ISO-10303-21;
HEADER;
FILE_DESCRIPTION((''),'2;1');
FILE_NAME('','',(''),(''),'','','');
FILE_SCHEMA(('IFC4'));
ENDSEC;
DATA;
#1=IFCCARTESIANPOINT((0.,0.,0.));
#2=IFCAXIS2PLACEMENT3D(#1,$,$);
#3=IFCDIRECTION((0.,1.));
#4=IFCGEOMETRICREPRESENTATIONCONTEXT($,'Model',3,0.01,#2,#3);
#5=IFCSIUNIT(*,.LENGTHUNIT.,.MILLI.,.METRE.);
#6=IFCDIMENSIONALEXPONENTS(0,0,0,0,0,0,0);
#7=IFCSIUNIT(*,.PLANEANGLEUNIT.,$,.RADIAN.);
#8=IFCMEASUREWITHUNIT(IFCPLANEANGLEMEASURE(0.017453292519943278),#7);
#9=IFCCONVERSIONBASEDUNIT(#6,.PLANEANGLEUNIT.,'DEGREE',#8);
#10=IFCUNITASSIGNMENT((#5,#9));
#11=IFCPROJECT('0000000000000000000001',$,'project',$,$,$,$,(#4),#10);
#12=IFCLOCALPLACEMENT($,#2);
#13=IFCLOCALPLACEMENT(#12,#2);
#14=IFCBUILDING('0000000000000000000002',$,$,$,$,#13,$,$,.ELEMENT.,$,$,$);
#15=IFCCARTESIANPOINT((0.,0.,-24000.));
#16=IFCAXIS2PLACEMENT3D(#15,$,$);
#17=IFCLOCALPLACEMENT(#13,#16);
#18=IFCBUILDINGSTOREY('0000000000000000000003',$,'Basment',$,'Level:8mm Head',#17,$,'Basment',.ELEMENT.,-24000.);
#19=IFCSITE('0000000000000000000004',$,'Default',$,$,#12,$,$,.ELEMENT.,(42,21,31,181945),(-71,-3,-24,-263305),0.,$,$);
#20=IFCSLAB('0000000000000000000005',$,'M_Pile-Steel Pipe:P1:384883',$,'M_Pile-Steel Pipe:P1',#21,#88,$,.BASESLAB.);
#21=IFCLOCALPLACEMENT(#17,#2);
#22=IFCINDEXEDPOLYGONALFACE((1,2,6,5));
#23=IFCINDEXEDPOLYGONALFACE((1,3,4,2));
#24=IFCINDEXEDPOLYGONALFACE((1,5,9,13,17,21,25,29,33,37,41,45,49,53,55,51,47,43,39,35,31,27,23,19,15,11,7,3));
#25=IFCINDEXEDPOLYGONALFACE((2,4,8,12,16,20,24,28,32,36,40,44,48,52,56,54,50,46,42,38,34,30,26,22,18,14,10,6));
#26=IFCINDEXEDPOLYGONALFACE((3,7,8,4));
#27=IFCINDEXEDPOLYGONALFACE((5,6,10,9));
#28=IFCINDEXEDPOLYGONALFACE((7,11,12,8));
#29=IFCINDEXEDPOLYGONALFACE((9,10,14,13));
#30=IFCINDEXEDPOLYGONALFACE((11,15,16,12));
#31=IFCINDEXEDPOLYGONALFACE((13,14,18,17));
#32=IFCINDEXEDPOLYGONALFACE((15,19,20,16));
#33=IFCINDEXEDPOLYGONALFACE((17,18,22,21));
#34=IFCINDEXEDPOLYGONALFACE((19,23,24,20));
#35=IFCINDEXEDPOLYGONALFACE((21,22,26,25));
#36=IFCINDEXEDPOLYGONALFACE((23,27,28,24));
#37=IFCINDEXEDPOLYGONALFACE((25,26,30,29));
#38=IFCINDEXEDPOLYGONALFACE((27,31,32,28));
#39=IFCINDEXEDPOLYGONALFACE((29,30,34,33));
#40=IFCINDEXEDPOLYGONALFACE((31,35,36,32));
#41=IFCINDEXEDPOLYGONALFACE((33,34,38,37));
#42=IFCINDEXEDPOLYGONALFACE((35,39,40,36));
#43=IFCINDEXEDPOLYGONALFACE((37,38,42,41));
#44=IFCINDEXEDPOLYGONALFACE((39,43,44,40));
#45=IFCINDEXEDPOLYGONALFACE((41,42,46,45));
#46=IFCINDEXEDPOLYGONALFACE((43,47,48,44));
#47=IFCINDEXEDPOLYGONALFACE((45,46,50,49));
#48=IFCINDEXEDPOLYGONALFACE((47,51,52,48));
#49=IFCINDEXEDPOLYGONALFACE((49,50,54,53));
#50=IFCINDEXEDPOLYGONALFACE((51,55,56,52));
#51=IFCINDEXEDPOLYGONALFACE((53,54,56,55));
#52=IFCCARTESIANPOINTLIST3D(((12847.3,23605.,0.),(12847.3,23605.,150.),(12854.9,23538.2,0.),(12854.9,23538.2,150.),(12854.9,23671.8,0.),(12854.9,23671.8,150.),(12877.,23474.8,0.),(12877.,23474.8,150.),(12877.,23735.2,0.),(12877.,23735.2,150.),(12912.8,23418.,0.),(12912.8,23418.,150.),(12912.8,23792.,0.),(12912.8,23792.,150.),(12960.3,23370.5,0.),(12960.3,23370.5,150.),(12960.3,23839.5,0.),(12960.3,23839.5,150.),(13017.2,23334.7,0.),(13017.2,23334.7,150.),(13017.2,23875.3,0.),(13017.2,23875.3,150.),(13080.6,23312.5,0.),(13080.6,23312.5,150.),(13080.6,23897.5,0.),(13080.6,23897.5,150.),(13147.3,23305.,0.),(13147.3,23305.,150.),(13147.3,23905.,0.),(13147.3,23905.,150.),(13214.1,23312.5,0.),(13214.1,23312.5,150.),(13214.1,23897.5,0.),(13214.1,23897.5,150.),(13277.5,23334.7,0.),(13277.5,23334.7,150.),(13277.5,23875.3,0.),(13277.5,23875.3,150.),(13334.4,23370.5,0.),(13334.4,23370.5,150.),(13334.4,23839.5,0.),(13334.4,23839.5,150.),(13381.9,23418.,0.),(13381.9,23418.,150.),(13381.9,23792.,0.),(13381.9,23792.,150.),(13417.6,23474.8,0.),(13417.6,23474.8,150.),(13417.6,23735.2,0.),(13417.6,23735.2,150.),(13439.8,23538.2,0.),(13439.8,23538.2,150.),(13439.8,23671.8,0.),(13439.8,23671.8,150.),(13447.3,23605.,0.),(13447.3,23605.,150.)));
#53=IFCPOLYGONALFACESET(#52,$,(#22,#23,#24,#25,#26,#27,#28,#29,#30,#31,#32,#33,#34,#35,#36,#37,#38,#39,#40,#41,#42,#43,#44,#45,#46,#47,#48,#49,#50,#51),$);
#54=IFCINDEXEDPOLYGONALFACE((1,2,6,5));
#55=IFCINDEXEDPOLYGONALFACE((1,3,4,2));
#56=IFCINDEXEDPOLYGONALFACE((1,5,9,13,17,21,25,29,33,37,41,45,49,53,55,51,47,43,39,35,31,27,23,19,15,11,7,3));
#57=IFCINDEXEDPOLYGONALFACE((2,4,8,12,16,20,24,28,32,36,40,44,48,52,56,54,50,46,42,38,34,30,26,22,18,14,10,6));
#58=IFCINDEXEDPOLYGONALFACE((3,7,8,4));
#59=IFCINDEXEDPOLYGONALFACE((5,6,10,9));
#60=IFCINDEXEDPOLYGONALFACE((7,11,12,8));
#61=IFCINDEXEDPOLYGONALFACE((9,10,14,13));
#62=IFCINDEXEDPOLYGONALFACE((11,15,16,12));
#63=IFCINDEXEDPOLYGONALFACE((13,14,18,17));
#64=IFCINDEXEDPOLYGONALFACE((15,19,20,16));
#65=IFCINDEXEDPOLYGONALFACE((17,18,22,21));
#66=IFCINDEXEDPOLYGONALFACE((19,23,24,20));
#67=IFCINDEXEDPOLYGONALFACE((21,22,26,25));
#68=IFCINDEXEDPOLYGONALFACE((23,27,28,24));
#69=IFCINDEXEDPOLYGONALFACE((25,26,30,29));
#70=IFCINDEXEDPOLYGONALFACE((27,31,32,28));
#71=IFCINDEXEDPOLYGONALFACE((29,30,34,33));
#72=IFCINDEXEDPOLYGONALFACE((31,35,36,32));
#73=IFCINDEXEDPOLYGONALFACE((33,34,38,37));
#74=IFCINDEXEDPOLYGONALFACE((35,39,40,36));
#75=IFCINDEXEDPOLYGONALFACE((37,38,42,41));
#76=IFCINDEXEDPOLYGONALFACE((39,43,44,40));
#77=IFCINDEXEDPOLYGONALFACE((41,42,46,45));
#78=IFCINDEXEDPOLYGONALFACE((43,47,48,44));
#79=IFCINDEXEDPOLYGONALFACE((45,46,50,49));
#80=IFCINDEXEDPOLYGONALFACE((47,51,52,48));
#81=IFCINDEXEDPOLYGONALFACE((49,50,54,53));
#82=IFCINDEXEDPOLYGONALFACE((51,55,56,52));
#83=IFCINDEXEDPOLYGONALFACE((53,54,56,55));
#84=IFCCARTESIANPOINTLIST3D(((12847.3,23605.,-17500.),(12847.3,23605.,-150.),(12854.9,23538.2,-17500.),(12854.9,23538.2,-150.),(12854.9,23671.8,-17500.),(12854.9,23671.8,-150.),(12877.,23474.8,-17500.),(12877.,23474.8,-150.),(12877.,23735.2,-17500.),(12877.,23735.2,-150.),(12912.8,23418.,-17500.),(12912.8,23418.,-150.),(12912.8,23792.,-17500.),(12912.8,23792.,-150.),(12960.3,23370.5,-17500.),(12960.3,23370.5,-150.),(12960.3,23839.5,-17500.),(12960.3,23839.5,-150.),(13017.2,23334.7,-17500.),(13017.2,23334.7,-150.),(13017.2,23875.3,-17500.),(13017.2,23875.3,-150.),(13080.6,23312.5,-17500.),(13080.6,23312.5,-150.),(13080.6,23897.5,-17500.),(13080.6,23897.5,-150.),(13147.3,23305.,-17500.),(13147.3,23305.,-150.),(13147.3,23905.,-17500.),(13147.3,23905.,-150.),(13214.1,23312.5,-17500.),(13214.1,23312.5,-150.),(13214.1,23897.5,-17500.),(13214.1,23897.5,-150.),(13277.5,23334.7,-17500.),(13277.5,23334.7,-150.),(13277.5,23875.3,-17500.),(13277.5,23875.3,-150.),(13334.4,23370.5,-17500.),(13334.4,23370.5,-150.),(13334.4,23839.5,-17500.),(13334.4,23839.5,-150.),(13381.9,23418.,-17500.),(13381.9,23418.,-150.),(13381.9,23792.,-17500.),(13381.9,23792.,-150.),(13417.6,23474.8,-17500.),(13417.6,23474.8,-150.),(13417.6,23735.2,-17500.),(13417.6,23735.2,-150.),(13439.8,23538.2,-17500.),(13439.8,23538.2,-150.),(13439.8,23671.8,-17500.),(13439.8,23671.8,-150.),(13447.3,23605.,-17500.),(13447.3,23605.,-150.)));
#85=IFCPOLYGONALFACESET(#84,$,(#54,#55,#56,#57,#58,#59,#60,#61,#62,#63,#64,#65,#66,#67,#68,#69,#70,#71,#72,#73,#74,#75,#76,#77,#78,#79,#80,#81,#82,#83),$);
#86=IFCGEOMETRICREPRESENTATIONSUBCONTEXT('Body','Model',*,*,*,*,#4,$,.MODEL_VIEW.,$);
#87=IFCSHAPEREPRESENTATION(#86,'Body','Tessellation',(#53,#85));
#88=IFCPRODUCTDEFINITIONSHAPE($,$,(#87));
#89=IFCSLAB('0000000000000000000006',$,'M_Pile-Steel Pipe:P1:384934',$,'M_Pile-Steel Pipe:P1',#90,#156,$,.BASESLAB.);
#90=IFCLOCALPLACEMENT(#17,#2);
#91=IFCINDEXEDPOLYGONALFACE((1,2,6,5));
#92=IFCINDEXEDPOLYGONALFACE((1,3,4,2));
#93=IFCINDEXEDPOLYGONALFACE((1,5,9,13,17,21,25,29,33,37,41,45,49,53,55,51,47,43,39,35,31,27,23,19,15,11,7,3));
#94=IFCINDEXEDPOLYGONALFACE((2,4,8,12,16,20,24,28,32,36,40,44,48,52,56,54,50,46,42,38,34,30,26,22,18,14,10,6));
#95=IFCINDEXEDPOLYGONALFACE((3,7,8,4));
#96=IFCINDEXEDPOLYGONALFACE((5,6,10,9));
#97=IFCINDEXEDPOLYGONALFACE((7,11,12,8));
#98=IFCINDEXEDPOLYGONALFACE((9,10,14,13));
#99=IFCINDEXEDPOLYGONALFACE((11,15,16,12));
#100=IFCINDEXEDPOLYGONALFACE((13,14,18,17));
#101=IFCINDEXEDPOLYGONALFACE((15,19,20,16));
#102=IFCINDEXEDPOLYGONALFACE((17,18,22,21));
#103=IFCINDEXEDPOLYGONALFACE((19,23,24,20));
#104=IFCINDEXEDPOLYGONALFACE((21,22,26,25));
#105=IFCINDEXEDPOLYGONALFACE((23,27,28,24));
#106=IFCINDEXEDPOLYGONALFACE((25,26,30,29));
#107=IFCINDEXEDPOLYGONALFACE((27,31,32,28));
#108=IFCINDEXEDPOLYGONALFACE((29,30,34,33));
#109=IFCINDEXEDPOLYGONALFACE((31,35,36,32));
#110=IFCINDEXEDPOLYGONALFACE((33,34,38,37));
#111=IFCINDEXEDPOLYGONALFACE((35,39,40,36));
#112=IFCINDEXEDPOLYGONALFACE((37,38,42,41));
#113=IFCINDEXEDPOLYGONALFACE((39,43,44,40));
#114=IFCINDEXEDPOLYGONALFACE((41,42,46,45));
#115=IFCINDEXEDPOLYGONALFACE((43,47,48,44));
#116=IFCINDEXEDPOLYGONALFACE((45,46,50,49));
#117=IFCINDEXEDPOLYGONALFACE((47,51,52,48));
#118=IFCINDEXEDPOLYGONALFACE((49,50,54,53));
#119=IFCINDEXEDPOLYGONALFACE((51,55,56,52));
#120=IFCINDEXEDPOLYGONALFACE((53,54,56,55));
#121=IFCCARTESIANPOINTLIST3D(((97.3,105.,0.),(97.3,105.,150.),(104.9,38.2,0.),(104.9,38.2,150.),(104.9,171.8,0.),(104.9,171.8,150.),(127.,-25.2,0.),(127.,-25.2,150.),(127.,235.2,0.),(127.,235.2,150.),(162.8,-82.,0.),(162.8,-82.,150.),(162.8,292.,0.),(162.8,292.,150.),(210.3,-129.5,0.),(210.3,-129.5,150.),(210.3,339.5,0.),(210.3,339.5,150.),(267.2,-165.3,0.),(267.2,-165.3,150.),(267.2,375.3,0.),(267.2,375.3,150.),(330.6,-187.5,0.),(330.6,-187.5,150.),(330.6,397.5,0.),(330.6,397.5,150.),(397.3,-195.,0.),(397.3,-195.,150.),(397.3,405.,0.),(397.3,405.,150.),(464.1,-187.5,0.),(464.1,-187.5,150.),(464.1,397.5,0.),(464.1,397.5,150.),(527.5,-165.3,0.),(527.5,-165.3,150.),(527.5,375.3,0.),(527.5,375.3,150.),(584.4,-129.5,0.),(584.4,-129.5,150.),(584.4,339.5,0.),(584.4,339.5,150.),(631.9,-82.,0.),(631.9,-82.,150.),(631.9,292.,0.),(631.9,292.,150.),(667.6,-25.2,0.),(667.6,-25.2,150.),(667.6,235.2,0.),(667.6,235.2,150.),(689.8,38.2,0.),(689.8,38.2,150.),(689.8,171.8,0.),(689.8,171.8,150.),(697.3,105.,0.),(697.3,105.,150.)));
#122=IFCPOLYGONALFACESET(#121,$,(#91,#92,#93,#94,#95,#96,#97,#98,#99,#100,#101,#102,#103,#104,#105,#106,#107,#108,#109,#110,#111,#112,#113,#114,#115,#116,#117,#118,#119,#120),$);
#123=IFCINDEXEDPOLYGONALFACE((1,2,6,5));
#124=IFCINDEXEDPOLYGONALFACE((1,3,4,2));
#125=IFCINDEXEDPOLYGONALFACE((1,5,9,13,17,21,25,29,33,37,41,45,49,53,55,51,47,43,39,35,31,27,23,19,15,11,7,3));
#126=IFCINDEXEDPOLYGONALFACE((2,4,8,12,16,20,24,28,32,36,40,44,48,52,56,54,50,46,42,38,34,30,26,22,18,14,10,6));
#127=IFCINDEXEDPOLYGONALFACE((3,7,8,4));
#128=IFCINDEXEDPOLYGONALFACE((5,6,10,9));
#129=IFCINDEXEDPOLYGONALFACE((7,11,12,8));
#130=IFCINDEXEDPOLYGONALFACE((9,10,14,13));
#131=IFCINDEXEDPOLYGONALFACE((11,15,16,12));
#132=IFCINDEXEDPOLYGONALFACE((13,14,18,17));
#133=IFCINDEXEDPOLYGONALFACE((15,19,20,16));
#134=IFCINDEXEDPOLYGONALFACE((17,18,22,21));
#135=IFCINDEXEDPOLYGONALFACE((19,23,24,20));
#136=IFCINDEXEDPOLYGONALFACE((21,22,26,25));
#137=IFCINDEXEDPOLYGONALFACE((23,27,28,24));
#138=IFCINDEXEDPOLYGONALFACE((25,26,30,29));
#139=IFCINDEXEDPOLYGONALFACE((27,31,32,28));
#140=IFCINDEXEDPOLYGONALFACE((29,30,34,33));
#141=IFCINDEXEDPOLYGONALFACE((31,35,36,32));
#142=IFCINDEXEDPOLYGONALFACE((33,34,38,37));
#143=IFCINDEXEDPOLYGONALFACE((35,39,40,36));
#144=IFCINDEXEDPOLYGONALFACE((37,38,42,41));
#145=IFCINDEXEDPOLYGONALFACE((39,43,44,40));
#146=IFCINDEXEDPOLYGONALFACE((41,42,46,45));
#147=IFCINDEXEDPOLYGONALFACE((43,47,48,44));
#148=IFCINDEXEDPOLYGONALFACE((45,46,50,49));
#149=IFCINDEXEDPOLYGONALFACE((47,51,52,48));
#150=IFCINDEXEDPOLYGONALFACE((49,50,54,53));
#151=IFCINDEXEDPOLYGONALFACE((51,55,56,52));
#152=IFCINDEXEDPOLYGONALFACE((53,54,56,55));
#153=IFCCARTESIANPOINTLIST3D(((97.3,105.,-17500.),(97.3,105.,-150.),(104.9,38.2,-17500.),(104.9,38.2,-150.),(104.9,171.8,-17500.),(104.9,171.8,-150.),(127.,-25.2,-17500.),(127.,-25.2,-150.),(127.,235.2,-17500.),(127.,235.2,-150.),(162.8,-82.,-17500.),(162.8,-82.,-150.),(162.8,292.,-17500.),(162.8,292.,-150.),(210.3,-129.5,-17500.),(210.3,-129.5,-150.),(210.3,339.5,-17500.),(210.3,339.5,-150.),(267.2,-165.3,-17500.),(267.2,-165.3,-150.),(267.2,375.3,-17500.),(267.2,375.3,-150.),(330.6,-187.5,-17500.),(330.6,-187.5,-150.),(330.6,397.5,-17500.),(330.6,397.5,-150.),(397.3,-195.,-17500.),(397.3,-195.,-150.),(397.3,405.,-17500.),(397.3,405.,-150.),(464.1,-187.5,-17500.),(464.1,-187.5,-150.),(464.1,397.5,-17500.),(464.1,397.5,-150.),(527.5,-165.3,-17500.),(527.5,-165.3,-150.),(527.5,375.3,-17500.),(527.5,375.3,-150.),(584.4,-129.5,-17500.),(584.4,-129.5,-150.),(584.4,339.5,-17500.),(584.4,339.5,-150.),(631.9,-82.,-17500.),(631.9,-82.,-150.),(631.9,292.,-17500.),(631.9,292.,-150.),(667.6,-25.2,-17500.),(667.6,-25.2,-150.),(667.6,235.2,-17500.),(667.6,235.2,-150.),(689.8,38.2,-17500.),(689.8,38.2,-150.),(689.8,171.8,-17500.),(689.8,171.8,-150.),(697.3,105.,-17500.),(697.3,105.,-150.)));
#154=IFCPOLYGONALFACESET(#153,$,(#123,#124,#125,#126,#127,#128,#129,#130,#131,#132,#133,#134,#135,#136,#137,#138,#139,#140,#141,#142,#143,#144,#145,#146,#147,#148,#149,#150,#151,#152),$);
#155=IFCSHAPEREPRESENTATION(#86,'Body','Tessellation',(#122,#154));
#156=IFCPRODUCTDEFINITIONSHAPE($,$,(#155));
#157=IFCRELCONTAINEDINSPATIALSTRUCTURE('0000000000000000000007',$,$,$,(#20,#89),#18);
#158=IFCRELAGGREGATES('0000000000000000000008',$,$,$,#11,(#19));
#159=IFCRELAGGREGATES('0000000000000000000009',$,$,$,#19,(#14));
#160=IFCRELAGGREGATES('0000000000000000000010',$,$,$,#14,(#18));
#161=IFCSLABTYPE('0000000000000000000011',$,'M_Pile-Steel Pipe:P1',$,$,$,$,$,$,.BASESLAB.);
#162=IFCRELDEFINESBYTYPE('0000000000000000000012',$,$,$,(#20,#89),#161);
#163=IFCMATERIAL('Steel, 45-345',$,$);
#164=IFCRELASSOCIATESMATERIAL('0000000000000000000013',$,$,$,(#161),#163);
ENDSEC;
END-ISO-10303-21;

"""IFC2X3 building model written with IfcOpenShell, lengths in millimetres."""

from ifc_helpers import new_model, entity, si_unit, converted_unit, direction, frame, frame_2d, origin, place, context, subcontext, project, spatial, circle, extrude, material, type_object, element, save


model = new_model("IFC2X3")

# Units and contexts
model_context = context("Model", 3, precision=0.01, world=origin(), true_north=direction((0.0, 1.0)))
body_context = subcontext(model_context, "Body", "Model", "MODEL_VIEW")
ifc_project = project(units=[si_unit("LENGTHUNIT", "METRE", prefix="MILLI"), converted_unit("PLANEANGLEUNIT", "DEGREE", entity("IfcPlaneAngleMeasure", 0.017453292519943278), si_unit("PLANEANGLEUNIT", "RADIAN"), dimensions=[0, 0, 0, 0, 0, 0, 0])], contexts=[model_context])

# Site, building, storey
site_placement = place(None, origin())
site = spatial("IfcSite", under=ifc_project, at=site_placement, Name="Default", CompositionType="ELEMENT", RefLatitude=(42, 21, 31, 181945), RefLongitude=(-71, -3, -24, -263305), RefElevation=0.0)
building_placement = place(site_placement, origin())
building = spatial("IfcBuilding", under=site, at=building_placement, CompositionType="ELEMENT")
storey_placement = place(building_placement, frame((0.0, 0.0, -24000.0)))
storey = spatial("IfcBuildingStorey", under=building, at=storey_placement, Name="Basment", ObjectType="Level:8mm Head", LongName="Basment", CompositionType="ELEMENT", Elevation=-24000.0)

# Slabs
ifc_material_1 = material(Name="Steel, 45-345")
slab_type_1 = type_object("IfcSlabType", Name="M_Pile-Steel Pipe:P1", PredefinedType="BASESLAB", material=ifc_material_1)
slab_1_placement = place(storey_placement, origin())
element("IfcSlab", 1, at=slab_1_placement, inside=storey, type_object=slab_type_1, Name="M_Pile-Steel Pipe:P1:384883", ObjectType="M_Pile-Steel Pipe:P1", PredefinedType="BASESLAB", context=body_context, shape_type="SweptSolid", body=[
    extrude(circle(Radius=300.0, at=frame_2d((0.0, 0.0), x_axis=(1.0, 0.0))), frame((13147.3, 23605.0, 0.0), z_axis=(0.0, 0.0, 1.0), x_axis=(0.0, 1.0, 0.0)), (0.0, 0.0, 1.0), 150.0),
    extrude(circle(Radius=300.0, at=frame_2d((0.0, 0.0), x_axis=(1.0, 0.0))), frame((13147.3, 23605.0, -17500.0), z_axis=(0.0, 0.0, 1.0), x_axis=(0.0, 1.0, 0.0)), (0.0, 0.0, 1.0), 17350.0),
])
slab_2_placement = place(storey_placement, origin())
element("IfcSlab", 2, at=slab_2_placement, inside=storey, type_object=slab_type_1, Name="M_Pile-Steel Pipe:P1:384934", ObjectType="M_Pile-Steel Pipe:P1", PredefinedType="BASESLAB", context=body_context, shape_type="SweptSolid", body=[
    extrude(circle(Radius=300.0, at=frame_2d((0.0, 0.0), x_axis=(1.0, 0.0))), frame((397.3, 105.0, 0.0), z_axis=(0.0, 0.0, 1.0), x_axis=(0.0, 1.0, 0.0)), (0.0, 0.0, 1.0), 150.0),
    extrude(circle(Radius=300.0, at=frame_2d((0.0, 0.0), x_axis=(1.0, 0.0))), frame((397.3, 105.0, -17500.0), z_axis=(0.0, 0.0, 1.0), x_axis=(0.0, 1.0, 0.0)), (0.0, 0.0, 1.0), 17350.0),
])

save(model, "model.ifc")
